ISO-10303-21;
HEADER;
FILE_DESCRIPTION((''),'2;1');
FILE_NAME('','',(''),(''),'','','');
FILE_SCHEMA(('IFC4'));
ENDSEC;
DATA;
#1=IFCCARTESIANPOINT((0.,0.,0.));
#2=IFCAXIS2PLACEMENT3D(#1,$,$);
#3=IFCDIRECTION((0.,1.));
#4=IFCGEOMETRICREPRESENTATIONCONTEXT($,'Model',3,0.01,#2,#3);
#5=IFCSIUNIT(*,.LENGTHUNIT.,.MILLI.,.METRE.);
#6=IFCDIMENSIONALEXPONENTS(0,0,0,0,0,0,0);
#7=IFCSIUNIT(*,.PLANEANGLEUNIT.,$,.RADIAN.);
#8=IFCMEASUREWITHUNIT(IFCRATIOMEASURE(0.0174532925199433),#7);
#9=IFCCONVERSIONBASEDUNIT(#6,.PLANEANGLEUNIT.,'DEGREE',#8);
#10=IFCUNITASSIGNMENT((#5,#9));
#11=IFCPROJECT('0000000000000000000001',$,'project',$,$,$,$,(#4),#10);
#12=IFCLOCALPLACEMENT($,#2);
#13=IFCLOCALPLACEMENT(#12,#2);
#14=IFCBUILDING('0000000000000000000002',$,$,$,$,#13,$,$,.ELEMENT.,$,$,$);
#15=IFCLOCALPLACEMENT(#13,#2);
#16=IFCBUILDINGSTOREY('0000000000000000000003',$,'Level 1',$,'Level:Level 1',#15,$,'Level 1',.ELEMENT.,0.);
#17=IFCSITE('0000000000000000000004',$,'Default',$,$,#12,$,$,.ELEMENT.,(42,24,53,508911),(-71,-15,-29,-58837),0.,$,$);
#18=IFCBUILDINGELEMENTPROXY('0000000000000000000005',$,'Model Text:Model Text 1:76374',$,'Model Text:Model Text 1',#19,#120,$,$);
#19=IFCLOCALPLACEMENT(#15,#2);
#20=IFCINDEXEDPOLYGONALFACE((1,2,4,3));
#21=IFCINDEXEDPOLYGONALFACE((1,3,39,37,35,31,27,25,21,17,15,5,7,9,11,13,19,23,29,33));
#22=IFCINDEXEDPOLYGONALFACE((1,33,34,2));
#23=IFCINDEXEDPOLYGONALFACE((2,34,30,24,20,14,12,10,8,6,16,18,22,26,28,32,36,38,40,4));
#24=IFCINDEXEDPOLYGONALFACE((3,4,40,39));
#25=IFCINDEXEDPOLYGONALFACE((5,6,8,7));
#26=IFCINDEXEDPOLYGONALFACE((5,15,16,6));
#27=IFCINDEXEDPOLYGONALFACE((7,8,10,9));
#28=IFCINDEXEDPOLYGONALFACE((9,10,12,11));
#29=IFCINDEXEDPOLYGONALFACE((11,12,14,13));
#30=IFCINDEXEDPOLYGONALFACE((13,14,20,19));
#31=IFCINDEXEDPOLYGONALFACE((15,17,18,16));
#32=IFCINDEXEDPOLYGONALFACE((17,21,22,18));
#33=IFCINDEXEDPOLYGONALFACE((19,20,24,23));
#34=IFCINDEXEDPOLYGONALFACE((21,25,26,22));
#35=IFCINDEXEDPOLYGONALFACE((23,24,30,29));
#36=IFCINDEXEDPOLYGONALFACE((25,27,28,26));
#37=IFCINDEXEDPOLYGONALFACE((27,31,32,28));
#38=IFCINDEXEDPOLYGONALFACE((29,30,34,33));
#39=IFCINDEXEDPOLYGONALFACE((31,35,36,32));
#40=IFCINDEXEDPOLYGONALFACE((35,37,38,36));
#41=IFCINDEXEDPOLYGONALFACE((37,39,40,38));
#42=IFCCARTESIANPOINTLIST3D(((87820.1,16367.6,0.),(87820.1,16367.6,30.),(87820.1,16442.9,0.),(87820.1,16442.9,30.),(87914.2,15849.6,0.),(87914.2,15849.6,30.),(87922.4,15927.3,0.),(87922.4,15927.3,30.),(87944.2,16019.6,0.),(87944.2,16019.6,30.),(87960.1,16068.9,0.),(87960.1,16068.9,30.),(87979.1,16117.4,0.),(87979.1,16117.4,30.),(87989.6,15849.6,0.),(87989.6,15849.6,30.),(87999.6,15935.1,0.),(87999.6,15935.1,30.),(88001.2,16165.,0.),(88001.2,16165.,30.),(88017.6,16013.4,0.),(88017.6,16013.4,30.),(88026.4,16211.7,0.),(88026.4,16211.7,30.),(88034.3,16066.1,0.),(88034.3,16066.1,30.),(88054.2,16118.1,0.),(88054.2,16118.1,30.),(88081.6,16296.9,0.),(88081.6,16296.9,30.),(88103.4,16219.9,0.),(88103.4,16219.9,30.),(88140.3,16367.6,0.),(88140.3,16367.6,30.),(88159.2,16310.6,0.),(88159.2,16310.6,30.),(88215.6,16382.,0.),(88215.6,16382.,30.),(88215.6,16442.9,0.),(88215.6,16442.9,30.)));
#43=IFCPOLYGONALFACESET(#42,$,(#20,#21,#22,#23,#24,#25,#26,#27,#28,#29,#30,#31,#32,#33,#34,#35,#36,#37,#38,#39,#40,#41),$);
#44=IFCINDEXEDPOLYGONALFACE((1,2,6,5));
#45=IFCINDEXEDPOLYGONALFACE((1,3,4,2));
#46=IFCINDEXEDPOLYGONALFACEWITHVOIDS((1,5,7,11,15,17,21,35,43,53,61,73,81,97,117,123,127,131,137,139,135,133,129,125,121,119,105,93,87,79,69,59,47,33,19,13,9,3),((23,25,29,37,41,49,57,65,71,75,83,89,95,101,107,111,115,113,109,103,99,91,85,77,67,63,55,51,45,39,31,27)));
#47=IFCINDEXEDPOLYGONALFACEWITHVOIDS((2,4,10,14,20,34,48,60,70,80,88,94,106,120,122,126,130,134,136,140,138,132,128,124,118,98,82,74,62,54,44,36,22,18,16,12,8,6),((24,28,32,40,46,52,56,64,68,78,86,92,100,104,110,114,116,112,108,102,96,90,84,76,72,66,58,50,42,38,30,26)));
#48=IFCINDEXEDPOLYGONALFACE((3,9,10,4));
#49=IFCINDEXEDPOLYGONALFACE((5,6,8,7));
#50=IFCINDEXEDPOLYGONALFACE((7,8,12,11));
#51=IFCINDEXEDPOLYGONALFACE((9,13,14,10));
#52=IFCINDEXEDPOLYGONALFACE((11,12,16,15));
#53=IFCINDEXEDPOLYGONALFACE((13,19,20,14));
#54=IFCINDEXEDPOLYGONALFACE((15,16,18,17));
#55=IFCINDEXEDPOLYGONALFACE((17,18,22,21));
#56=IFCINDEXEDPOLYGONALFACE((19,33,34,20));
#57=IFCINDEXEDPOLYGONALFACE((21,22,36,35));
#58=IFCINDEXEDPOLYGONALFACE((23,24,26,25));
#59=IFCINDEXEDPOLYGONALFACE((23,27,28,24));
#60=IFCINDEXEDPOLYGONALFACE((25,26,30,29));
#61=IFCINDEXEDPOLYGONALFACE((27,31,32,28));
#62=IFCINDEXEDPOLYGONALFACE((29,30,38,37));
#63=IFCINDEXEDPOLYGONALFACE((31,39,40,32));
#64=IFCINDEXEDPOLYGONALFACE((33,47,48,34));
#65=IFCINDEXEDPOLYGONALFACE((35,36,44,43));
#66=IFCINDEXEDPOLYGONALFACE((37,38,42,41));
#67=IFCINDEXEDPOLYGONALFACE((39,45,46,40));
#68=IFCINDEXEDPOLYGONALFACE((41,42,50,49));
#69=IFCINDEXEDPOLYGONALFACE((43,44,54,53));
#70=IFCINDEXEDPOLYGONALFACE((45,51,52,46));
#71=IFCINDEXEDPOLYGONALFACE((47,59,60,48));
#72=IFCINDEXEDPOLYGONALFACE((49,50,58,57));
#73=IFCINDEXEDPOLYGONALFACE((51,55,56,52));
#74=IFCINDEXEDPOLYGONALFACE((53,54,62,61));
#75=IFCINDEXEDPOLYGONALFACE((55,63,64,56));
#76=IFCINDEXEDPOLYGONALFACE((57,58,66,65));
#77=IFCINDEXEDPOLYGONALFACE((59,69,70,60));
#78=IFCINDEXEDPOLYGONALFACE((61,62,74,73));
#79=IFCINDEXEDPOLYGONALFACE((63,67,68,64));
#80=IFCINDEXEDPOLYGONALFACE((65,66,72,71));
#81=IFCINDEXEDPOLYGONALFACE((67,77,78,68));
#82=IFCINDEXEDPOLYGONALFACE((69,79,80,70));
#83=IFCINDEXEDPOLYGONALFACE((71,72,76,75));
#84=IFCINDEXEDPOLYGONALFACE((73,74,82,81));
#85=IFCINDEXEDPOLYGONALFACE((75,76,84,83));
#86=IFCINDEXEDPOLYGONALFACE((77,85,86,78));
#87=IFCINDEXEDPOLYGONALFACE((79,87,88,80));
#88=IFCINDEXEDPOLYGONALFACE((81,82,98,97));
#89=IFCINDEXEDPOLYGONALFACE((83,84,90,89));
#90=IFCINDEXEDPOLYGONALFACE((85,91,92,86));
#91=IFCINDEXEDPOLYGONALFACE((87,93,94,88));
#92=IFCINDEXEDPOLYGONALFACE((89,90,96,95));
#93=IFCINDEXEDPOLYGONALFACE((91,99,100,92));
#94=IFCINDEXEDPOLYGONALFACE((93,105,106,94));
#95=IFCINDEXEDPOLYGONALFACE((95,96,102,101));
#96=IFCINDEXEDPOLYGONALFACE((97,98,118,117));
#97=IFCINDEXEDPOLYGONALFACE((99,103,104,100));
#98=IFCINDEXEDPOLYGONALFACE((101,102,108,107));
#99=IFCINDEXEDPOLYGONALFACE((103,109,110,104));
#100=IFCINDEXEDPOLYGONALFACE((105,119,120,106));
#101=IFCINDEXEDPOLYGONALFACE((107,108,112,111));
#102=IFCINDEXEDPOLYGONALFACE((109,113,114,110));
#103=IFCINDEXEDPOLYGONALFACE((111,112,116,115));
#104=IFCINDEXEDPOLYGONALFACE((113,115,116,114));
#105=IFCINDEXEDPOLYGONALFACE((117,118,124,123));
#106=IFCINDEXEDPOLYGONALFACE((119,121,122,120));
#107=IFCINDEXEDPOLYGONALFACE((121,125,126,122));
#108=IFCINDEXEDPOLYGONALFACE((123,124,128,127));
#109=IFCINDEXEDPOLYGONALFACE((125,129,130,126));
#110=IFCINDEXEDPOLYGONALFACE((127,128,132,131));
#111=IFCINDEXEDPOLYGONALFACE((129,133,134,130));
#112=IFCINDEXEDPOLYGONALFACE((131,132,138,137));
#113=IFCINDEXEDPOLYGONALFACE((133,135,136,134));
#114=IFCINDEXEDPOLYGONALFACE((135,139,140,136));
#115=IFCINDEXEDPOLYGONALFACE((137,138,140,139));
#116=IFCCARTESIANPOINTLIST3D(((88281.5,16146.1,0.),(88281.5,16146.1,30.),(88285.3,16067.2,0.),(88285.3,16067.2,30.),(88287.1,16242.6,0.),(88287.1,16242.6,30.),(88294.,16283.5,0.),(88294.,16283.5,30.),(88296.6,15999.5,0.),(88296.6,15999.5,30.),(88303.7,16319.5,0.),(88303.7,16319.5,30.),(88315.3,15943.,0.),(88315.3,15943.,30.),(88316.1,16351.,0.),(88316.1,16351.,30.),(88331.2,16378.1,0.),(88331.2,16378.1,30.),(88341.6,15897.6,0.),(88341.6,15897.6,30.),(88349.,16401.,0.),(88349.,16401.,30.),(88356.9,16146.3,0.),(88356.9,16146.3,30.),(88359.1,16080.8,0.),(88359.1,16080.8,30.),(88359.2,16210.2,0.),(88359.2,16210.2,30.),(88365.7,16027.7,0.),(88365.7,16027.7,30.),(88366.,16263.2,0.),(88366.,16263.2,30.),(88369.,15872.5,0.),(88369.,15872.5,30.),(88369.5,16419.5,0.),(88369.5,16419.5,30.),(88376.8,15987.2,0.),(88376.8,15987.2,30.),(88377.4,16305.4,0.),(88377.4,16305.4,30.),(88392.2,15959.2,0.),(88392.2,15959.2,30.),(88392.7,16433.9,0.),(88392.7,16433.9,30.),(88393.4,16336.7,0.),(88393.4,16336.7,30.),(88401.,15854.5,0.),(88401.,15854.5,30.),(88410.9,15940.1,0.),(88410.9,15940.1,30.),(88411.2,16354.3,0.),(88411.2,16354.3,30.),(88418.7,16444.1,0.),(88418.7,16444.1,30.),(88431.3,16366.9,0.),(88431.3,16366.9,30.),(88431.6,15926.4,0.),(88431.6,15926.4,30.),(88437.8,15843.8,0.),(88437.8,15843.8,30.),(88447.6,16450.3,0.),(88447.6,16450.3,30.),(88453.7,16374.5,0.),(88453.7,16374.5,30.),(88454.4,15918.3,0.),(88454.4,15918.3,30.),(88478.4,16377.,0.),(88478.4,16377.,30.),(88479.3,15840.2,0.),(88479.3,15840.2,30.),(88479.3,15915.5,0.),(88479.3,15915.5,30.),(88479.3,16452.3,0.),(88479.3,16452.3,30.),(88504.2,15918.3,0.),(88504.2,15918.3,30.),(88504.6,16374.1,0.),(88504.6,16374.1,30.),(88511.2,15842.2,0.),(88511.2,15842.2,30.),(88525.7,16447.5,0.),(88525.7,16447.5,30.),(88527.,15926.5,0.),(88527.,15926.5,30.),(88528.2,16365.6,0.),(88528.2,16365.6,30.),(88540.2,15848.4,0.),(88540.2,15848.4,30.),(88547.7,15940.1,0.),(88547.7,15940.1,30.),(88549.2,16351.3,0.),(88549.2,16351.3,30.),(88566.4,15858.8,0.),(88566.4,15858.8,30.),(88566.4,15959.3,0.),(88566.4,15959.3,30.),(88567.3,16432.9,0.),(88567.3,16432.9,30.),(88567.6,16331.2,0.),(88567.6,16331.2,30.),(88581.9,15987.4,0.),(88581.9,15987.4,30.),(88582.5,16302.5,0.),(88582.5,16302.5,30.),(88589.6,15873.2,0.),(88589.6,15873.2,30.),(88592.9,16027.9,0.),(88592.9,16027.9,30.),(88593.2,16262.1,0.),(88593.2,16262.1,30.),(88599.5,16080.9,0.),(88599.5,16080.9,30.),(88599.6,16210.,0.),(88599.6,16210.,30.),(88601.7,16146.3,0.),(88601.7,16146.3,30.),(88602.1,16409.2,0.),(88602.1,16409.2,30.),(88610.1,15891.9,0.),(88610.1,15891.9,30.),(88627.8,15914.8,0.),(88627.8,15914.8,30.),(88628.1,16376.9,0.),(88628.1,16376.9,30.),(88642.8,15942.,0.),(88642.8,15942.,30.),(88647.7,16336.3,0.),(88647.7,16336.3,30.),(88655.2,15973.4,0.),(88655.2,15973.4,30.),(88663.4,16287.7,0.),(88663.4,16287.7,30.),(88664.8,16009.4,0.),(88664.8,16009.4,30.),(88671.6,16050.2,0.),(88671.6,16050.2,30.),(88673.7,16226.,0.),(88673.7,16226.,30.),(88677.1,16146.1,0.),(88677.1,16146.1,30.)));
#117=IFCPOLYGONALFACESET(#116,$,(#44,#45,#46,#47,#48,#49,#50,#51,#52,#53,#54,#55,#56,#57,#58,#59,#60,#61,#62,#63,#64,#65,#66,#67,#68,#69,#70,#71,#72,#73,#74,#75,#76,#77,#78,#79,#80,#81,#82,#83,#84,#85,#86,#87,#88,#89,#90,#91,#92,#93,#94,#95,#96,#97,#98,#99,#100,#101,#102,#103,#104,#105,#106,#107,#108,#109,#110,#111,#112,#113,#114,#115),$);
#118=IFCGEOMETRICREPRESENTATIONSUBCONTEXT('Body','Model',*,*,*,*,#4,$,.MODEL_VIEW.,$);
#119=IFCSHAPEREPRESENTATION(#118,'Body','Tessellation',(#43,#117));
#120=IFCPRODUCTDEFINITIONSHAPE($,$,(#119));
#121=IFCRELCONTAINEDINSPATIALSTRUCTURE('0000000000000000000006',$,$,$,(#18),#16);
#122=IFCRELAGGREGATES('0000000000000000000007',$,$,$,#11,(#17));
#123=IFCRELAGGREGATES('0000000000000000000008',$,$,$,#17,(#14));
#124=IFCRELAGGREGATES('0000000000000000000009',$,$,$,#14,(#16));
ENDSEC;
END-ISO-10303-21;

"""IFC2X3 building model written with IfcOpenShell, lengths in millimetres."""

from ifc_helpers import new_model, entity, si_unit, converted_unit, direction, frame, origin, place, context, subcontext, project, spatial, polyline, outline, extrude, element, save


model = new_model("IFC2X3")

# Units and contexts
model_context = context("Model", 3, precision=0.01, world=origin(), true_north=direction((0.0, 1.0)))
body_context = subcontext(model_context, "Body", "Model", "MODEL_VIEW")
ifc_project = project(units=[si_unit("LENGTHUNIT", "METRE", prefix="MILLI"), converted_unit("PLANEANGLEUNIT", "DEGREE", entity("IfcRatioMeasure", 0.0174532925199433), si_unit("PLANEANGLEUNIT", "RADIAN"), dimensions=[0, 0, 0, 0, 0, 0, 0])], contexts=[model_context])

# Site, building, storey
site_placement = place(None, origin())
site = spatial("IfcSite", under=ifc_project, at=site_placement, Name="Default", CompositionType="ELEMENT", RefLatitude=(42, 24, 53, 508911), RefLongitude=(-71, -15, -29, -58837), RefElevation=0.0)
building_placement = place(site_placement, origin())
building = spatial("IfcBuilding", under=site, at=building_placement, CompositionType="ELEMENT")
storey_placement = place(building_placement, origin())
storey = spatial("IfcBuildingStorey", under=building, at=storey_placement, Name="Level 1", ObjectType="Level:Level 1", LongName="Level 1", CompositionType="ELEMENT", Elevation=0.0)

# Building element proxy
proxy_1_placement = place(storey_placement, origin())
element("IfcBuildingElementProxy", 1, at=proxy_1_placement, inside=storey, Name="Model Text:Model Text 1:76374", ObjectType="Model Text:Model Text 1", context=body_context, shape_type="SweptSolid", body=[
    extrude(outline(polyline([(-199.9, -209.0), (-199.9, -284.3), (195.7, -284.3), (195.7, -223.4), (139.3, -152.0), (83.5, -61.3), (34.2, 40.5), (14.4, 92.5), (-2.4, 145.2), (-20.3, 223.5), (-30.3, 309.0), (-105.7, 309.0), (-97.5, 231.3), (-75.7, 139.0), (-59.9, 89.7), (-40.9, 41.2), (-18.8, -6.4), (6.4, -53.1), (61.7, -138.3), (120.3, -209.0), (-199.9, -209.0)])), frame((88019.9, 16158.6, 0.0), z_axis=(0.0, 0.0, -1.0), x_axis=(1.0, 0.0, 0.0)), (0.0, 0.0, -1.0), 30.0),
    extrude(outline(polyline([(-10.6, -198.7), (68.3, -198.7), (136.5, -190.7), (193.9, -174.7), (240.5, -150.6), (266.9, -124.4), (286.3, -93.2), (298.8, -57.0), (304.3, -15.7), (303.8, 16.2), (299.0, 45.5), (289.9, 72.1), (276.6, 96.0), (258.9, 117.3), (236.9, 136.2), (210.4, 152.5), (179.6, 166.3), (144.1, 177.6), (103.7, 186.3), (8.2, 196.4), (-71.8, 196.7), (-134.0, 189.4), (-183.3, 176.1), (-224.7, 158.4), (-258.2, 133.9), (-283.5, 100.3), (-300.1, 59.5), (-307.1, 13.4), (-306.6, -18.4), (-301.8, -47.5), (-292.8, -74.0), (-279.6, -97.9), (-262.0, -119.2), (-240.0, -138.1), (-213.6, -154.5), (-182.8, -168.4), (-147.3, -179.8), (-106.7, -188.6), (-10.6, -198.7)]), holes=[polyline([(-7.2, -123.5), (-71.0, -118.2), (-123.6, -108.8), (-165.2, -95.4), (-195.7, -78.0), (-212.4, -59.4), (-224.1, -38.7), (-230.6, -15.9), (-231.9, 8.9), (-227.8, 35.0), (-218.1, 58.1), (-202.8, 78.4), (-182.0, 95.8), (-152.6, 109.4), (-111.7, 118.1), (-59.4, 122.0), (4.4, 121.1), (69.6, 115.8), (122.2, 106.7), (162.2, 93.7), (189.5, 77.0), (207.7, 57.4), (220.4, 36.0), (227.5, 12.8), (229.1, -12.1), (225.2, -36.8), (215.9, -59.2), (201.3, -79.3), (181.4, -97.1), (152.6, -111.2), (111.6, -120.3), (58.3, -124.4), (-7.2, -123.5)])]), frame((88480.6, 16144.9, 0.0), z_axis=(0.0, 0.0, 1.0), x_axis=(0.047515, -0.998871, 0.0)), (0.0, 0.0, 1.0), 30.0),
])

save(model, "model.ifc")
